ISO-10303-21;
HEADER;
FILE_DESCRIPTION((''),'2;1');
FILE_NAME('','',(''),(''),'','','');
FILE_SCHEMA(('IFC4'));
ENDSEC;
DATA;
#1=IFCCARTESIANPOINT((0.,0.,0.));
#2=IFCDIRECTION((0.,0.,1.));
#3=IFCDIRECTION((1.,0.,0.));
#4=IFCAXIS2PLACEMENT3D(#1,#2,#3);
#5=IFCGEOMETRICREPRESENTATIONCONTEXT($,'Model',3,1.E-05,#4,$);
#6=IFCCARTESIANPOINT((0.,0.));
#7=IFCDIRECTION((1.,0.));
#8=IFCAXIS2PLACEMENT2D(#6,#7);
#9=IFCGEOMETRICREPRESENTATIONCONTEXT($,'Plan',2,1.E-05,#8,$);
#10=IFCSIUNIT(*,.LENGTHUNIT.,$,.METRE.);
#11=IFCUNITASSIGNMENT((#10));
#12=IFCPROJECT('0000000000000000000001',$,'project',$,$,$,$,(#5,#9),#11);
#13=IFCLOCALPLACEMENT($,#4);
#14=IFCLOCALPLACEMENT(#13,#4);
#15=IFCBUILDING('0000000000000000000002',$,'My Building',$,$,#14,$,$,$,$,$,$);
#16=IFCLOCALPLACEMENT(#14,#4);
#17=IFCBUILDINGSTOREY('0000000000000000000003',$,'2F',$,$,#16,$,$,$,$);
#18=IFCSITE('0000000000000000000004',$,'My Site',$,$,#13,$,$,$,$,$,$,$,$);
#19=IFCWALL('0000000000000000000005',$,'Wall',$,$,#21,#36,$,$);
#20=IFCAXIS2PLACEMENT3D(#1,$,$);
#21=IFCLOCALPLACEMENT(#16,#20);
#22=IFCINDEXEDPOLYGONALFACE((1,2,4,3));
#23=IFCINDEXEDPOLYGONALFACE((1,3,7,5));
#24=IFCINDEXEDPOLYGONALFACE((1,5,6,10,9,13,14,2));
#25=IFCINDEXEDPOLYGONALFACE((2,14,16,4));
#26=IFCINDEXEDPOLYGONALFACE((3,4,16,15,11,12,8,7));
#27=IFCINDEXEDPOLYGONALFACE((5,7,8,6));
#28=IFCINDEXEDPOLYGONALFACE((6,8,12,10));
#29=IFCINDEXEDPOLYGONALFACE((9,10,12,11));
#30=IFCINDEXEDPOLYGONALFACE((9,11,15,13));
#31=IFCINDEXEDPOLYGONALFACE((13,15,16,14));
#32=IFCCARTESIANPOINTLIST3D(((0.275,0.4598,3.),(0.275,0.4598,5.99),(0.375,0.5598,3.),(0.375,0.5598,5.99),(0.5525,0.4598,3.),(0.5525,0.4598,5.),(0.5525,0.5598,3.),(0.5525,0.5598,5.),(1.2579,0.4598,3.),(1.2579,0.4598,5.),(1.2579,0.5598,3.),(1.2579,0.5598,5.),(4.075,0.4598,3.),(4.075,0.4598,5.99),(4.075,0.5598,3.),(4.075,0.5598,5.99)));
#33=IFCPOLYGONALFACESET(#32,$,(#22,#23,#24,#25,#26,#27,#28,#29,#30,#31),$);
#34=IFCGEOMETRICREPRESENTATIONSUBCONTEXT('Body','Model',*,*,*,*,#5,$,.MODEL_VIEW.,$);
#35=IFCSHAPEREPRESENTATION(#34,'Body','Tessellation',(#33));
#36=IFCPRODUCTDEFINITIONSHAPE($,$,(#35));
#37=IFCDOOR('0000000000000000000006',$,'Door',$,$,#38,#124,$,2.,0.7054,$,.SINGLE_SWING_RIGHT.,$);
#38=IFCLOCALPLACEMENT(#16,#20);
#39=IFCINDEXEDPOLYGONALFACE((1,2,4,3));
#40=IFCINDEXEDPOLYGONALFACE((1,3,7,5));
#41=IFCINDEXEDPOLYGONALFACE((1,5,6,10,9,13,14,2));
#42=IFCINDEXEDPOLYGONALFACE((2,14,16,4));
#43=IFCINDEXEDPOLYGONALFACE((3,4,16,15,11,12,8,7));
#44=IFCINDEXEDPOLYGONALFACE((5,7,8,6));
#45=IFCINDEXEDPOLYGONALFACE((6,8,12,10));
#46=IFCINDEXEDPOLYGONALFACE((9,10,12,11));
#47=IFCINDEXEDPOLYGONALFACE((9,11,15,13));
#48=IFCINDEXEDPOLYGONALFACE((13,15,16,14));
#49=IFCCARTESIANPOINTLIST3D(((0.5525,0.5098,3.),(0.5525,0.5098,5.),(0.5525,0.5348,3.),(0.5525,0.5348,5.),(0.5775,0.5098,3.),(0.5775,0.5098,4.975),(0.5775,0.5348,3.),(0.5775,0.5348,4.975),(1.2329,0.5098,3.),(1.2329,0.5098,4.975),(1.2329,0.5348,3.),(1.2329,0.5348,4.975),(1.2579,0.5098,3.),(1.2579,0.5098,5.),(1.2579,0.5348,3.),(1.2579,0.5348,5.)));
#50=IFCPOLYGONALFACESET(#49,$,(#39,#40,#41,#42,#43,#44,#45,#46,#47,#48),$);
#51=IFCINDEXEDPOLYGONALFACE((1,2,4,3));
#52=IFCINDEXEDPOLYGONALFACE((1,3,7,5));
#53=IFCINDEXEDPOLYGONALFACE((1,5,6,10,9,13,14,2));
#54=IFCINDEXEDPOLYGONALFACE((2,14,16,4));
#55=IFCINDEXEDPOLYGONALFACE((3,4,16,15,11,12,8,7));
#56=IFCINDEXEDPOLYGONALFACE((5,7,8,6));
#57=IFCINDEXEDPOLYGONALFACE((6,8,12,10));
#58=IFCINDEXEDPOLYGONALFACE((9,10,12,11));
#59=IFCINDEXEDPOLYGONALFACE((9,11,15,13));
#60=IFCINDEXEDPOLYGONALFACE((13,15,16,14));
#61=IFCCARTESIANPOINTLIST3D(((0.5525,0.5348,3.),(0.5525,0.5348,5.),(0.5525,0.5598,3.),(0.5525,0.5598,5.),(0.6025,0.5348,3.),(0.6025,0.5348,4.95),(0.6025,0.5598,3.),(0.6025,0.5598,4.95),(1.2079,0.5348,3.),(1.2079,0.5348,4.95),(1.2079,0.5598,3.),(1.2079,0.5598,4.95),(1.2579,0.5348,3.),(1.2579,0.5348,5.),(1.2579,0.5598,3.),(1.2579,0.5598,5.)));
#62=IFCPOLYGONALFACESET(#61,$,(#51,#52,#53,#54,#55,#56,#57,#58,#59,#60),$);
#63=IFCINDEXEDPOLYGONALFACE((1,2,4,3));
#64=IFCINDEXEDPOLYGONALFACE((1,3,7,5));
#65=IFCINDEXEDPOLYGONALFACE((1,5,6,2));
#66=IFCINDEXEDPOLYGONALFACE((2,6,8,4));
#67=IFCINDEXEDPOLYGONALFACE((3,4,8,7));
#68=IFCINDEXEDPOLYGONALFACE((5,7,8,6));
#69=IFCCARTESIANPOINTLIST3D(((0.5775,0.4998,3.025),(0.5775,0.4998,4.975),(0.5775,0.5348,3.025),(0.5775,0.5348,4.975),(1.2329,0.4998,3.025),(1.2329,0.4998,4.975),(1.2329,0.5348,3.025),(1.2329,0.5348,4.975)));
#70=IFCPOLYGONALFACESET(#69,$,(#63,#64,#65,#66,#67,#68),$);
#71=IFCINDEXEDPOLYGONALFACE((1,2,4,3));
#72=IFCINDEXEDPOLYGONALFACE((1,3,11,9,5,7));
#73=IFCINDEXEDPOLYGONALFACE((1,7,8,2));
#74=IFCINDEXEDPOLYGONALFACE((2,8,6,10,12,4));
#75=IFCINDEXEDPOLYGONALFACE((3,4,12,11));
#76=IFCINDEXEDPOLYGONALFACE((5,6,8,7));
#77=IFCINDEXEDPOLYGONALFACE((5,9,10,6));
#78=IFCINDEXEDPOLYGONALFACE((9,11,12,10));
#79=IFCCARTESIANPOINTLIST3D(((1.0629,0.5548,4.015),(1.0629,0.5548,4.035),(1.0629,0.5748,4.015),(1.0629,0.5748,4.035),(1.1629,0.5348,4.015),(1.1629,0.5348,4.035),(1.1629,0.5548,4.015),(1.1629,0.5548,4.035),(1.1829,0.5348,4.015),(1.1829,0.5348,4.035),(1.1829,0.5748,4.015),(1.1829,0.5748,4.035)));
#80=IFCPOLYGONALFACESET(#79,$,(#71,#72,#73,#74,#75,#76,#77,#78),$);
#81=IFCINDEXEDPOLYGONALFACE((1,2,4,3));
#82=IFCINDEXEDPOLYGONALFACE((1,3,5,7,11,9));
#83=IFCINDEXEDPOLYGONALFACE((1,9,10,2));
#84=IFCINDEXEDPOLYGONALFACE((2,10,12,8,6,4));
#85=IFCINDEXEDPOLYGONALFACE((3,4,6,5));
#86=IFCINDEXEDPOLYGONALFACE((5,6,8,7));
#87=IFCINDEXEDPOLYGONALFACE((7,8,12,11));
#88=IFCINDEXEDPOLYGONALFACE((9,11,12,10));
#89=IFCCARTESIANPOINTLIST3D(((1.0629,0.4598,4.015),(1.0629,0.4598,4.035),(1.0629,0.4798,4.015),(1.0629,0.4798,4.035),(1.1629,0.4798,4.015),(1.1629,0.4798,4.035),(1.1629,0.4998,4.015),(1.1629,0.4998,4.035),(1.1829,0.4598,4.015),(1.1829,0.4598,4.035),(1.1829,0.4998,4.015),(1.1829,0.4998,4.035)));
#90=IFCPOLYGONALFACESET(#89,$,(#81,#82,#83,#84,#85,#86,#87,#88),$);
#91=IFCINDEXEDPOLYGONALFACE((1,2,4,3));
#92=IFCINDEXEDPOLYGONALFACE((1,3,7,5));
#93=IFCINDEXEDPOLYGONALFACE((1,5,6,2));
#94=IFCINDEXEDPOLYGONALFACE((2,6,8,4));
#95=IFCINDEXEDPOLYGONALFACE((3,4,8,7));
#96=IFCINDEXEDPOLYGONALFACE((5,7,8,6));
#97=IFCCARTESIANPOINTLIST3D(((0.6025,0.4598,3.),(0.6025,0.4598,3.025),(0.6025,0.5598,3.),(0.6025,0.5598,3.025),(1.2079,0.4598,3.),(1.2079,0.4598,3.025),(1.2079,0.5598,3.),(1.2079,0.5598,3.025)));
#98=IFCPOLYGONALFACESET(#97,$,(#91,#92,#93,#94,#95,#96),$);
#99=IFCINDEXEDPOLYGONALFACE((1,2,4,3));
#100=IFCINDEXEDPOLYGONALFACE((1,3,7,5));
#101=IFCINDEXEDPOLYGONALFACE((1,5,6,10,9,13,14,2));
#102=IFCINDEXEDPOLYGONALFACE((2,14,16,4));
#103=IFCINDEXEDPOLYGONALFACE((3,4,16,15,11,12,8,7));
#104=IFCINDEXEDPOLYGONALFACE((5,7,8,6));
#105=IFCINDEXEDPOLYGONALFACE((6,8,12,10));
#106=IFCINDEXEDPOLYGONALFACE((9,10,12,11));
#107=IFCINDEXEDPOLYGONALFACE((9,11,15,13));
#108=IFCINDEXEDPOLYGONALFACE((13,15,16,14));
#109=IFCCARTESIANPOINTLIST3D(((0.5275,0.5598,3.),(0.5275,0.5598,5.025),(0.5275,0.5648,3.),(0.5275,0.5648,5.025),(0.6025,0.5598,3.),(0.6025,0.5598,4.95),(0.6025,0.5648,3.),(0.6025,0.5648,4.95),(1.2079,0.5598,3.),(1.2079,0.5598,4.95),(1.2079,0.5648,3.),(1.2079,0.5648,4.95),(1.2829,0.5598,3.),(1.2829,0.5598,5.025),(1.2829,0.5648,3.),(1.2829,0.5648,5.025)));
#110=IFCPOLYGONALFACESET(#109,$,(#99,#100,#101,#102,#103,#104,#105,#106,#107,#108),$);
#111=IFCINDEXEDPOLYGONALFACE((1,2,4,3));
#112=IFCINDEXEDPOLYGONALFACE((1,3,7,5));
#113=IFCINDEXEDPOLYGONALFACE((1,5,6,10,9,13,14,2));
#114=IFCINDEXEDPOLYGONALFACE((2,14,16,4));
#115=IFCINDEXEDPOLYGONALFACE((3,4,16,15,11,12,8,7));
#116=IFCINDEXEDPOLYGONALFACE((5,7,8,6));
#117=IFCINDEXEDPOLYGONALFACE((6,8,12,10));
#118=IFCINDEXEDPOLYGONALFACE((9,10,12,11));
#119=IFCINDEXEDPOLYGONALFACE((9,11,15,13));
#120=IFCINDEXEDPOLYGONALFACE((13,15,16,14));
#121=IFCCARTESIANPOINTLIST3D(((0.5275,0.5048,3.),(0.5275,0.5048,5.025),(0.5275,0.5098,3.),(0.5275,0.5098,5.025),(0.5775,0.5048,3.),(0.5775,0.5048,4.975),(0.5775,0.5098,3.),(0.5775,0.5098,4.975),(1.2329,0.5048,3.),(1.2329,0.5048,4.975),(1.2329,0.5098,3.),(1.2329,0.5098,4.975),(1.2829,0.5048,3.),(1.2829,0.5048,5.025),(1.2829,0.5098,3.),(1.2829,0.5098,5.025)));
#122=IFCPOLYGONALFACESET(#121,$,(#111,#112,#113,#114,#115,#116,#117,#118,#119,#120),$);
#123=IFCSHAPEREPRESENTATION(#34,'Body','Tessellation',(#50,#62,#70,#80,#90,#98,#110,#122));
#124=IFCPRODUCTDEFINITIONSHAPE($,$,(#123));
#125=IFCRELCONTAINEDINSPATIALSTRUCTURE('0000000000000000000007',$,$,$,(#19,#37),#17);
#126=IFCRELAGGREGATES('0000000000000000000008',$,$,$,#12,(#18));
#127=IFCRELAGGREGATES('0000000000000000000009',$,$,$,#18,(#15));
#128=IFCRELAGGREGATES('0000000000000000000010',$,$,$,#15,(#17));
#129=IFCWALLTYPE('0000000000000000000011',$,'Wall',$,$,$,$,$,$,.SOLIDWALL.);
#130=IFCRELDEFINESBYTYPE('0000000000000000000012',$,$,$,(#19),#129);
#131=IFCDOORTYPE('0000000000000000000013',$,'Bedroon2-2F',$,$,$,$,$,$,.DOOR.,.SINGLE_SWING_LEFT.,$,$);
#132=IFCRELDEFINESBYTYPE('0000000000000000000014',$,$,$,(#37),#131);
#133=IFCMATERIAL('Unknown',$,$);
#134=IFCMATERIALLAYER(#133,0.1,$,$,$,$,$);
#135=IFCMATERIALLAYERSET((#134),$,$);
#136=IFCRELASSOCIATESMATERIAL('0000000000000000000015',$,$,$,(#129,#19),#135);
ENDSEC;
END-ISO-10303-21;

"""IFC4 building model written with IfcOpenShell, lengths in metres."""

from ifc_helpers import new_model, entity, si_unit, frame, origin_with_axes, origin_2d_with_axis, place, context, subcontext, project, spatial, line, indexed_curve, outline, extrude, shape, source, transform, mapped, material, layer, layer_set, layer_usage, type_object, type_shapes, element, fill, save


model = new_model("IFC4")

# Units and contexts
model_context = context("Model", 3, precision=1e-05, world=origin_with_axes())
plan_context = context("Plan", 2, precision=1e-05, world=origin_2d_with_axis())
body_context_1 = subcontext(model_context, "Body", "Model", "MODEL_VIEW")
body_context_2 = subcontext(plan_context, "Body", "Plan", "PLAN_VIEW")
ifc_project = project(units=[si_unit("LENGTHUNIT", "METRE")], contexts=[model_context, plan_context])

# Site, building, storey
site_placement = place(None, origin_with_axes())
site = spatial("IfcSite", under=ifc_project, at=site_placement, Name="My Site")
building_placement = place(site_placement, origin_with_axes())
building = spatial("IfcBuilding", under=site, at=building_placement, Name="My Building")
storey_placement = place(building_placement, origin_with_axes())
storey = spatial("IfcBuildingStorey", under=building, at=storey_placement, Name="2F")

# Shared definitions
ifc_material = material(Name="Unknown")

# Shared definitions
ifc_layer_1 = layer(ifc_material, 0.1)
ifc_layer_set_1 = layer_set([ifc_layer_1])
wall_type = type_object("IfcWallType", Name="Wall", PredefinedType="SOLIDWALL", material=ifc_layer_set_1)

# Wall, opening, door
ifc_layer_usage_1 = layer_usage(ifc_layer_set_1, "AXIS2", "POSITIVE", 0.0)
wall_1_placement = place(storey_placement, frame((0.275, 0.4598, 3.0), z_axis=(0.0, 0.0, 1.0), x_axis=(1.0, 0.0, 0.0)))
wall_1 = element("IfcWall", 1, at=wall_1_placement, inside=storey, type_object=wall_type, material=ifc_layer_usage_1, Name="Wall", context=body_context_1, shape_type="SweptSolid", body=[
    extrude(outline(indexed_curve([(0.0, 0.0), (0.1, 0.1), (3.8, 0.1), (3.8, 0.0)], segments=[line(1, 2, 3, 4, 1)])), origin_with_axes(), (0.0, 0.0, 1.0), 2.99),
])
shared_shape_1 = source(origin_with_axes(), body_context_1, "Body", "SweptSolid", [
    extrude(outline(indexed_curve([(0.0, 0.0), (0.7054, 0.0), (0.7054, 2.0), (0.0, 2.0)], segments=[line(1, 2, 3, 4, 1)])), frame((0.0, -0.6, 0.0), z_axis=(0.0, -1.0, 0.0), x_axis=(1.0, 0.0, 0.0)), (0.0, 0.0, -1.0), 1.2),
])
opening_1_placement = place(wall_1_placement, frame((0.9829, 0.1, 0.0), z_axis=(0.0, 0.0, 1.0), x_axis=(-1.0, 0.0, 0.0)))
opening_1 = element("IfcOpeningElement", 2, at=opening_1_placement, cuts=wall_1, PredefinedType="OPENING", context=body_context_1, shape_type="MappedRepresentation", body=[
    mapped(shared_shape_1, transform((0.0, 0.0, 0.0), x_axis=(1.0, 0.0, 0.0), y_axis=(0.0, 1.0, 0.0), z_axis=(0.0, 0.0, 1.0), scale=1.0)),
])
door_type_1 = type_object("IfcDoorType", Name="Bedroon2-2F", OperationType="SINGLE_SWING_LEFT", PredefinedType="DOOR")
shared_shape_2 = source(origin_with_axes(), body_context_1, "Body", "SweptSolid", [
    extrude(outline(indexed_curve([(0.0, 0.0), (0.0, 2.0), (0.7054, 2.0), (0.7054, 0.0), (0.6804, 0.0), (0.6804, 1.975), (0.025, 1.975), (0.025, 0.0)], segments=[line(1, 2, 3, 4, 5, 6, 7, 8, 1)])), frame((0.0, 0.025, 0.0), z_axis=(0.0, -1.0, 0.0), x_axis=(1.0, 0.0, 0.0)), (0.0, 0.0, -1.0), 0.025),
    extrude(outline(indexed_curve([(0.0, 0.0), (0.0, 2.0), (0.7054, 2.0), (0.7054, 0.0), (0.6554, 0.0), (0.6554, 1.95), (0.05, 1.95), (0.05, 0.0)], segments=[line(1, 2, 3, 4, 5, 6, 7, 8, 1)])), frame((0.0, 0.0, 0.0), z_axis=(0.0, -1.0, 0.0), x_axis=(1.0, 0.0, 0.0)), (0.0, 0.0, -1.0), 0.025),
    extrude(outline(indexed_curve([(0.0, 0.0), (0.6554, 0.0), (0.6554, 0.035), (0.0, 0.035)], segments=[line(1, 2, 3, 4, 1)])), frame((0.025, 0.025, 0.025), z_axis=(0.0, 0.0, 1.0), x_axis=(1.0, 0.0, 0.0)), (0.0, 0.0, 1.0), 1.95),
    extrude(outline(indexed_curve([(0.0, 0.0), (0.0, -0.04), (0.12, -0.04), (0.12, -0.02), (0.02, -0.02), (0.02, 0.0)], segments=[line(1, 2, 3, 4, 5, 6, 1)])), frame((0.075, 0.025, 1.015), z_axis=(0.0, 0.0, 1.0), x_axis=(1.0, 0.0, 0.0)), (0.0, 0.0, 1.0), 0.02),
    extrude(outline(indexed_curve([(0.0, 0.0), (0.0, 0.04), (0.12, 0.04), (0.12, 0.02), (0.02, 0.02), (0.02, 0.0)], segments=[line(1, 2, 3, 4, 5, 6, 1)])), frame((0.075, 0.06, 1.015), z_axis=(0.0, 0.0, 1.0), x_axis=(1.0, 0.0, 0.0)), (0.0, 0.0, 1.0), 0.02),
    extrude(outline(indexed_curve([(0.0, 0.0), (0.6054, 0.0), (0.6054, 0.1), (0.0, 0.1)], segments=[line(1, 2, 3, 4, 1)])), frame((0.05, 0.0, 0.0), z_axis=(0.0, 0.0, 1.0), x_axis=(1.0, 0.0, 0.0)), (0.0, 0.0, 1.0), 0.025),
    extrude(outline(indexed_curve([(0.0, 0.0), (0.0, 2.025), (0.7554, 2.025), (0.7554, 0.0), (0.6804, 0.0), (0.6804, 1.95), (0.075, 1.95), (0.075, 0.0)], segments=[line(1, 2, 3, 4, 5, 6, 7, 8, 1)])), frame((-0.025, -0.005, 0.0), z_axis=(0.0, -1.0, 0.0), x_axis=(1.0, 0.0, 0.0)), (0.0, 0.0, -1.0), 0.005),
    extrude(outline(indexed_curve([(0.0, 0.0), (0.0, 2.025), (0.7554, 2.025), (0.7554, 0.0), (0.7054, 0.0), (0.7054, 1.975), (0.05, 1.975), (0.05, 0.0)], segments=[line(1, 2, 3, 4, 5, 6, 7, 8, 1)])), frame((-0.025, 0.05, 0.0), z_axis=(0.0, -1.0, 0.0), x_axis=(1.0, 0.0, 0.0)), (0.0, 0.0, -1.0), 0.005),
])
shared_shape_3 = source(origin_with_axes(), body_context_2, "Body", "Curve2D", [
    entity("IfcIndexedPolyCurve", entity("IfcCartesianPointList2D", [[0.0, 0.0], [0.0, 0.05], [0.025, 0.05], [0.025, 0.025], [0.05, 0.025], [0.05, 0.0]]), [entity("IfcLineIndex", [1, 2, 3, 4, 5, 6, 1])]),
    entity("IfcIndexedPolyCurve", entity("IfcCartesianPointList2D", [[0.7054, 0.0], [0.7054, 0.05], [0.6804, 0.05], [0.6804, 0.025], [0.6554, 0.025], [0.6554, 0.0]]), [entity("IfcLineIndex", [1, 2, 3, 4, 5, 6, 1])]),
    entity("IfcTrimmedCurve", entity("IfcEllipse", entity("IfcAxis2Placement2D", entity("IfcCartesianPoint", [0.6454, 0.05]), entity("IfcDirection", [1.0, 0.0])), 0.6204, 0.6554), [entity("IfcCartesianPoint", [0.6454, 0.7054])], [entity("IfcCartesianPoint", [0.025, 0.05])], True, "CARTESIAN"),
    entity("IfcIndexedPolyCurve", entity("IfcCartesianPointList2D", [[0.6804, 0.05], [0.6454, 0.05], [0.6454, 0.7054], [0.6804, 0.7054]]), [entity("IfcLineIndex", [1, 2, 3, 4, 1])]),
])
type_shapes(door_type_1, [shared_shape_2, shared_shape_3])
door_1_placement = place(opening_1_placement, origin_with_axes())
door_1 = element("IfcDoor", 3, at=door_1_placement, inside=storey, type_object=door_type_1, Name="Door", OperationType="SINGLE_SWING_RIGHT", OverallHeight=2.0, OverallWidth=0.7054, shapes=[
    shape(body_context_1, "Body", "MappedRepresentation", [mapped(shared_shape_2, transform((0.0, 0.0, 0.0), x_axis=(1.0, 0.0, 0.0), y_axis=(0.0, 1.0, 0.0), z_axis=(0.0, 0.0, 1.0), scale=1.0))]),
    shape(body_context_2, "Body", "MappedRepresentation", [mapped(shared_shape_3, transform((0.0, 0.0, 0.0), x_axis=(1.0, 0.0, 0.0), y_axis=(0.0, 1.0, 0.0), z_axis=(0.0, 0.0, 1.0), scale=1.0))]),
])
fill(opening_1, door_1)

save(model, "model.ifc")
